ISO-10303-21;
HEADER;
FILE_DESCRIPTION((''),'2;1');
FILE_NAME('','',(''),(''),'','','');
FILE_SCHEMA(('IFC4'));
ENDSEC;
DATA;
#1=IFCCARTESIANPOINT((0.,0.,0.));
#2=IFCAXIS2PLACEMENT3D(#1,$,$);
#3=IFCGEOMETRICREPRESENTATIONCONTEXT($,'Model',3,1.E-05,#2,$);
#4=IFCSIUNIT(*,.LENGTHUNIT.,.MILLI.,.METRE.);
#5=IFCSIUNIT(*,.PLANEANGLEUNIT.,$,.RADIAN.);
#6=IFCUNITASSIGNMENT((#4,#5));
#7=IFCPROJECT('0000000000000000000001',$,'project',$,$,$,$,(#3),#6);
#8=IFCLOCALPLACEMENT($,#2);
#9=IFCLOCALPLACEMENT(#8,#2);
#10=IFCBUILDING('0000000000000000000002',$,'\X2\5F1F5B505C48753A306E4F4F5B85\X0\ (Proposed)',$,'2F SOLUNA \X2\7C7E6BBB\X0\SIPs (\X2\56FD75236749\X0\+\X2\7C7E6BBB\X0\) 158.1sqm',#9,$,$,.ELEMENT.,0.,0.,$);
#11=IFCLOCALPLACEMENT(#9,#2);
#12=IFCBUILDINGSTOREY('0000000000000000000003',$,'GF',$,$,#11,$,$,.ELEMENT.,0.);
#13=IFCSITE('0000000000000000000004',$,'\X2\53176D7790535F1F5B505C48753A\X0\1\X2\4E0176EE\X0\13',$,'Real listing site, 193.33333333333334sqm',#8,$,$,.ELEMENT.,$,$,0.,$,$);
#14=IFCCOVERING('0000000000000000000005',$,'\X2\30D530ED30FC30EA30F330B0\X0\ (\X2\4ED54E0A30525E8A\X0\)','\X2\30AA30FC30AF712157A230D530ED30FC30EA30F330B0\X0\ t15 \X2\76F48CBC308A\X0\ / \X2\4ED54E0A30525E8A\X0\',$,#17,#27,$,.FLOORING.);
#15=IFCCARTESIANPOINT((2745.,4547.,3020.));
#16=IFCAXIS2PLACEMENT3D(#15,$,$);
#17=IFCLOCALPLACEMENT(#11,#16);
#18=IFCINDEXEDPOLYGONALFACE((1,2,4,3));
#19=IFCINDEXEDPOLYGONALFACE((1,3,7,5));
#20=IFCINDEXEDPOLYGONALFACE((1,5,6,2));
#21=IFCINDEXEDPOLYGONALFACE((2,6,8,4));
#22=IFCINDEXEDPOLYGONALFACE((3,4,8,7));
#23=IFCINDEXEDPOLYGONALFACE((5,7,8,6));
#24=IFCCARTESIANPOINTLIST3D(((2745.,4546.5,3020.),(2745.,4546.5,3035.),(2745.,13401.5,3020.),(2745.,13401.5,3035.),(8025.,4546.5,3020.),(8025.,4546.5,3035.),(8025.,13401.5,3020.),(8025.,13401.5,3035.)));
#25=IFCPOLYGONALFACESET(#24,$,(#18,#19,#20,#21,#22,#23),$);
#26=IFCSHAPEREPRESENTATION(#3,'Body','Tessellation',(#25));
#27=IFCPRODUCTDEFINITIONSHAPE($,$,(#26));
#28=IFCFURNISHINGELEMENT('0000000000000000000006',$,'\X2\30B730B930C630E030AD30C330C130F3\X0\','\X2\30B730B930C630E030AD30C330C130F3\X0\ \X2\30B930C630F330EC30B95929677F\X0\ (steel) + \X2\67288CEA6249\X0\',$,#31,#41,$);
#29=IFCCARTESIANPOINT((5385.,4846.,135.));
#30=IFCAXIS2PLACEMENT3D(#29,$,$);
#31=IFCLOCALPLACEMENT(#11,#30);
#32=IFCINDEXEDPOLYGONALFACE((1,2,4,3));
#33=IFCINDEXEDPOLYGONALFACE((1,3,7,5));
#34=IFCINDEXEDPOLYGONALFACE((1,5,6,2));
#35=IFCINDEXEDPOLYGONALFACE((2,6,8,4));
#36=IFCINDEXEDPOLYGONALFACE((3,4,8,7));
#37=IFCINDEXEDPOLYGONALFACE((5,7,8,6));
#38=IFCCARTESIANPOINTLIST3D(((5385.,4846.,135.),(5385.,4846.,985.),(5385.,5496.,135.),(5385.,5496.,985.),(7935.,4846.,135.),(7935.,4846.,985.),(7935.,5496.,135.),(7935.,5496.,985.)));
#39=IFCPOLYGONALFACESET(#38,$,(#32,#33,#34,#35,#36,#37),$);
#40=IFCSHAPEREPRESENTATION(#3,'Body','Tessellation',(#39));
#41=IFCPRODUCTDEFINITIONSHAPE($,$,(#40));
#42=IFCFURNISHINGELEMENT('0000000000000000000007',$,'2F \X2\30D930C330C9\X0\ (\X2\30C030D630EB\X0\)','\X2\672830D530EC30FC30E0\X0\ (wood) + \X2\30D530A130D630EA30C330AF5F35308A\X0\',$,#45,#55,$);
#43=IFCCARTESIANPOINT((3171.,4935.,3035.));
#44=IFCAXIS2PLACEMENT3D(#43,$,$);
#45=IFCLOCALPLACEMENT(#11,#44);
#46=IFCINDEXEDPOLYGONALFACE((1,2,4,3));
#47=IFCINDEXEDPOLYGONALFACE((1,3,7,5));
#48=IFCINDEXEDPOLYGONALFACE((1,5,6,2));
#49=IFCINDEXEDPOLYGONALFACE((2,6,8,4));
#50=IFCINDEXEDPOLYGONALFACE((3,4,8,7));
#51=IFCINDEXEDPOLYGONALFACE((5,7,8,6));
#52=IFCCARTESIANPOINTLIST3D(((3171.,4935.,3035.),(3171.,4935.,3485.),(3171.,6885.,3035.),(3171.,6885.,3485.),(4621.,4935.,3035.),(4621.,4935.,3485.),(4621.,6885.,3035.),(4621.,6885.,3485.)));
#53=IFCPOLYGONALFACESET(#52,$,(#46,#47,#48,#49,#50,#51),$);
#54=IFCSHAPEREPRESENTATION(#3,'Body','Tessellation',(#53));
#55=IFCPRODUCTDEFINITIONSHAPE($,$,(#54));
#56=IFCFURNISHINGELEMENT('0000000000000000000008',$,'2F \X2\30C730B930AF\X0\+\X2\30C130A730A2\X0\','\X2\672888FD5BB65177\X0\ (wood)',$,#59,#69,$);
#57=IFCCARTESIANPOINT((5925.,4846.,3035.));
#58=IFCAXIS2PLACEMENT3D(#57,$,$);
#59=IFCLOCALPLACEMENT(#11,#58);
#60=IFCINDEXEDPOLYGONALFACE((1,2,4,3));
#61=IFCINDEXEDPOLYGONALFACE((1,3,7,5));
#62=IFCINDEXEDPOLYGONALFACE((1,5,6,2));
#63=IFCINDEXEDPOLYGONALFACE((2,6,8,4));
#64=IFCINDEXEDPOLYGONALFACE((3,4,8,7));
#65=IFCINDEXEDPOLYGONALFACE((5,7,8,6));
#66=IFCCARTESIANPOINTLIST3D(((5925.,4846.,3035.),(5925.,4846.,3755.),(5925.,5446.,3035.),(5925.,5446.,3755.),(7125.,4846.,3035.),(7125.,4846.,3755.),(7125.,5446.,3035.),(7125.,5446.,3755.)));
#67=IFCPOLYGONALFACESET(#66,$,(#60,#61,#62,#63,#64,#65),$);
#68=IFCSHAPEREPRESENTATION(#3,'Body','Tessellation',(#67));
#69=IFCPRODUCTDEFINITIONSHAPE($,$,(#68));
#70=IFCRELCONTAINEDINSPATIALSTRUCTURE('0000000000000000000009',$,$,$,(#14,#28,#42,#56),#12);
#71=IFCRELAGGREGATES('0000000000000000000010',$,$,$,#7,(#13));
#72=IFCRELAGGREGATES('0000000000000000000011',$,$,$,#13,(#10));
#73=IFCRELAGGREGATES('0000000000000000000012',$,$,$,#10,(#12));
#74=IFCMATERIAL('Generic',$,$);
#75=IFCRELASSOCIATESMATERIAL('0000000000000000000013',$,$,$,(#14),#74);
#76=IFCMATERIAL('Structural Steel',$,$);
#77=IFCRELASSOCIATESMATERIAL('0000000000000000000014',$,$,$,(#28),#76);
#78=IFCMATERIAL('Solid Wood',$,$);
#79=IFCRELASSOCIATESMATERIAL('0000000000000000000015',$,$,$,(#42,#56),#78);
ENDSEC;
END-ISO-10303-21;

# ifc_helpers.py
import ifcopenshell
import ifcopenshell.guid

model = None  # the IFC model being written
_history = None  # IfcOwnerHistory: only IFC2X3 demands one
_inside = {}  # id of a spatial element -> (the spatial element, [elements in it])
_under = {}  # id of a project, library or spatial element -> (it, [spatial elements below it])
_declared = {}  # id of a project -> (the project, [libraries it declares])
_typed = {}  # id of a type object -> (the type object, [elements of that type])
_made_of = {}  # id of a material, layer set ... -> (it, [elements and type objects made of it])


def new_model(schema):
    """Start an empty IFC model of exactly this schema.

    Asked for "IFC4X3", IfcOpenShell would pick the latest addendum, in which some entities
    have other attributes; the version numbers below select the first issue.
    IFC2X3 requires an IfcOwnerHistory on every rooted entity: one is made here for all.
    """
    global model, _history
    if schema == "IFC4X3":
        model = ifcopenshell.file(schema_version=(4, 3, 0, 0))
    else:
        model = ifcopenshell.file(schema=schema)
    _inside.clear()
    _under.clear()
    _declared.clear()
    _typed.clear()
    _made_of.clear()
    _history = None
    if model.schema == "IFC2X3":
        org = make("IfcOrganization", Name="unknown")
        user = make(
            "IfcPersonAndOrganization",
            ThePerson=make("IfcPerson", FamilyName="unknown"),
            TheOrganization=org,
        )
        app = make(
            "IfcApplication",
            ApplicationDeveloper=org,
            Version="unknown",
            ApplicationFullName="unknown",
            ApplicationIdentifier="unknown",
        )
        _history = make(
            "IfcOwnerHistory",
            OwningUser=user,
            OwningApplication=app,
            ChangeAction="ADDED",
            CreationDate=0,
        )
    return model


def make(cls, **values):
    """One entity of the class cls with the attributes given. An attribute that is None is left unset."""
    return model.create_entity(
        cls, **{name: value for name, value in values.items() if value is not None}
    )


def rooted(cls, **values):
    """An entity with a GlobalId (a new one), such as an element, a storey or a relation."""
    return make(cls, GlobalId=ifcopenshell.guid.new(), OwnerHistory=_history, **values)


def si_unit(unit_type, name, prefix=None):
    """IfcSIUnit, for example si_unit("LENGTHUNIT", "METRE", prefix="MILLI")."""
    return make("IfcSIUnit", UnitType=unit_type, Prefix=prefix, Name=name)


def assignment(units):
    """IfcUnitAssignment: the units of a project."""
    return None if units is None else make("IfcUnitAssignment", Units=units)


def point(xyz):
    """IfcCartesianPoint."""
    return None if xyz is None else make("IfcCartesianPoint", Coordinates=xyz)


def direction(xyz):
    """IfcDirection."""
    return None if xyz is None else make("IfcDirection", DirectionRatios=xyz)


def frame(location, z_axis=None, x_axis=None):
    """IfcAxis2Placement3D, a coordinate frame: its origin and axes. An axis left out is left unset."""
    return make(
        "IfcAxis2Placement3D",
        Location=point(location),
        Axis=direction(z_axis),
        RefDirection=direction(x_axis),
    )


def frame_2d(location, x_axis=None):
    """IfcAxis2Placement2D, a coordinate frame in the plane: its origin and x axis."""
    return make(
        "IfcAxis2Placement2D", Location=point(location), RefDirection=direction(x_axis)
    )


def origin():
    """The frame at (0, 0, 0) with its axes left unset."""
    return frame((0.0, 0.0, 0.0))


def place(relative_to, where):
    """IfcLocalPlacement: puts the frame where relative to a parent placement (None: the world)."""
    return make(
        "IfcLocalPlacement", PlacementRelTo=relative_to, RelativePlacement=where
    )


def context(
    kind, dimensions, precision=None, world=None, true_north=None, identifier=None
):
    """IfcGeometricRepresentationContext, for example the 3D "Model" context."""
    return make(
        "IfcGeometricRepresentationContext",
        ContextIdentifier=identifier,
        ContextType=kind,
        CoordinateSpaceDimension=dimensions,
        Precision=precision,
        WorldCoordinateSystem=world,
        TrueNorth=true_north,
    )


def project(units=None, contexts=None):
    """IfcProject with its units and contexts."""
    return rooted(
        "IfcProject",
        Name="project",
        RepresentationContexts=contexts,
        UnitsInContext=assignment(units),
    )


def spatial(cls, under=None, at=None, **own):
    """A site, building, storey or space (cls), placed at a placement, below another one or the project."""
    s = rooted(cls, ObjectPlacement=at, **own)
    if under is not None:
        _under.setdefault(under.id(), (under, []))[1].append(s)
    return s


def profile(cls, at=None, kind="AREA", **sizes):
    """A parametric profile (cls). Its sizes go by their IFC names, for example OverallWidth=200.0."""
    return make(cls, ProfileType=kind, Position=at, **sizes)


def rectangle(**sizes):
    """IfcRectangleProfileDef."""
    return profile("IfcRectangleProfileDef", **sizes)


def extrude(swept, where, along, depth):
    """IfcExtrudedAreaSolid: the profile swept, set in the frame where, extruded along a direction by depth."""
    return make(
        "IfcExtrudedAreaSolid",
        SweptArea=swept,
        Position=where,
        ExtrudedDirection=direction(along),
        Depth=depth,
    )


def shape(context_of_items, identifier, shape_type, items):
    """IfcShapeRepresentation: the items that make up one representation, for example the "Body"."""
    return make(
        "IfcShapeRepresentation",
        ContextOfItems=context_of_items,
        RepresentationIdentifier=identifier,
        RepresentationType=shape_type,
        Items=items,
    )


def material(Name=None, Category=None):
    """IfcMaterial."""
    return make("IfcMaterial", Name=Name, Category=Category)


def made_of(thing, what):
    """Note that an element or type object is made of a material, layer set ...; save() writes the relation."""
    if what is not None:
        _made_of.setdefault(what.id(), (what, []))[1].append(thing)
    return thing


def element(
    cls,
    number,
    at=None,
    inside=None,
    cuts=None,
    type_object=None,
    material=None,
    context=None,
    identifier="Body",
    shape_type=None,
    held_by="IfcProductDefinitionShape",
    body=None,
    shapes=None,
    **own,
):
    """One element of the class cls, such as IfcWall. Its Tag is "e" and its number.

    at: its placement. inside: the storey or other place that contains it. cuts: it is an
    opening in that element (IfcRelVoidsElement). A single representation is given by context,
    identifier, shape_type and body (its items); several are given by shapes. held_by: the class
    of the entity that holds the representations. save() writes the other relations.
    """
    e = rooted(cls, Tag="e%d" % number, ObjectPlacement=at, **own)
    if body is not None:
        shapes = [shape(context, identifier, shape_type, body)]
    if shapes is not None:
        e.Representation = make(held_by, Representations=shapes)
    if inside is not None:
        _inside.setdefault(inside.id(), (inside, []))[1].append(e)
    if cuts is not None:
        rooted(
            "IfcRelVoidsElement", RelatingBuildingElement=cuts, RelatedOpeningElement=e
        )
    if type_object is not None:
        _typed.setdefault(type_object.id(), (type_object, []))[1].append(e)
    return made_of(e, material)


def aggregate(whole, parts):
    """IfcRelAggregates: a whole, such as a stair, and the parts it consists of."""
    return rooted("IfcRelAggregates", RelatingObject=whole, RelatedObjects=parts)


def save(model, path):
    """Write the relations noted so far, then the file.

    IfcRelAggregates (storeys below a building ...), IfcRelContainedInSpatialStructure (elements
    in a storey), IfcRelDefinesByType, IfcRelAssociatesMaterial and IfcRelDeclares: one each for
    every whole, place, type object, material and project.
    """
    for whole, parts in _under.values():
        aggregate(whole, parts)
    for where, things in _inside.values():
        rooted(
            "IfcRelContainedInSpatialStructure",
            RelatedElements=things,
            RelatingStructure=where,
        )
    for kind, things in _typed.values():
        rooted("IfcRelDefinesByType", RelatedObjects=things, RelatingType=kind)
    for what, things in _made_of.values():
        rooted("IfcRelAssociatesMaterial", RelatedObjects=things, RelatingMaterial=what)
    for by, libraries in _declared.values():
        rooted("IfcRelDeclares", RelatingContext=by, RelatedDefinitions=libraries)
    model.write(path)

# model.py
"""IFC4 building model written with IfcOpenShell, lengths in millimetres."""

from ifc_helpers import new_model, si_unit, frame, frame_2d, origin, place, context, project, spatial, rectangle, extrude, material, element, save


model = new_model("IFC4")

# Units and contexts
model_context = context("Model", 3, precision=1e-05, world=origin())
ifc_project = project(units=[si_unit("LENGTHUNIT", "METRE", prefix="MILLI"), si_unit("PLANEANGLEUNIT", "RADIAN")], contexts=[model_context])

# Site, building, storey
site_placement = place(None, origin())
site = spatial("IfcSite", under=ifc_project, at=site_placement, Name="北海道弟子屈町1丁目13", ObjectType="Real listing site, 193.33333333333334sqm", CompositionType="ELEMENT", RefElevation=0.0)
building_placement = place(site_placement, origin())
building = spatial("IfcBuilding", under=site, at=building_placement, Name="弟子屈町の住宅 (Proposed)", ObjectType="2F SOLUNA 籾殻SIPs (国産杉+籾殻) 158.1sqm", CompositionType="ELEMENT", ElevationOfRefHeight=0.0, ElevationOfTerrain=0.0)
storey_placement = place(building_placement, origin())
storey = spatial("IfcBuildingStorey", under=building, at=storey_placement, Name="GF", CompositionType="ELEMENT", Elevation=0.0)

# Shared definitions
ifc_material_1 = material(Name="Solid Wood")

# Shared definitions
ifc_material_2 = material(Name="Generic")

# Shared definitions
ifc_material_3 = material(Name="Structural Steel")

# Covering
covering_placement = place(storey_placement, frame((2745.0, 4547.0, 3020.0)))
element("IfcCovering", 1, at=covering_placement, inside=storey, material=ifc_material_2, Name="フローリング (仕上げ床)", Description="オーク無垢フローリング t15 直貼り / 仕上げ床", PredefinedType="FLOORING", context=model_context, shape_type="SweptSolid", body=[
    extrude(rectangle(XDim=5280.0, YDim=8855.0, at=frame_2d((2640.0, 4427.0))), frame((2745.0, 4547.0, 3020.0)), (0.0, 0.0, 1.0), 15.0),
])

# Furnishing elements
furnishing_1_placement = place(storey_placement, frame((5385.0, 4846.0, 135.0)))
element("IfcFurnishingElement", 2, at=furnishing_1_placement, inside=storey, material=ifc_material_3, Name="システムキッチン", Description="システムキッチン ステンレス天板 (steel) + 木質扉", context=model_context, shape_type="SweptSolid", body=[
    extrude(rectangle(XDim=2550.0, YDim=650.0, at=frame_2d((1275.0, 325.0))), frame((5385.0, 4846.0, 135.0)), (0.0, 0.0, 1.0), 850.0),
])
furnishing_2_placement = place(storey_placement, frame((3171.0, 4935.0, 3035.0)))
element("IfcFurnishingElement", 3, at=furnishing_2_placement, inside=storey, material=ifc_material_1, Name="2F ベッド (ダブル)", Description="木フレーム (wood) + ファブリック張り", context=model_context, shape_type="SweptSolid", body=[
    extrude(rectangle(XDim=1450.0, YDim=1950.0, at=frame_2d((725.0, 975.0))), frame((3171.0, 4935.0, 3035.0)), (0.0, 0.0, 1.0), 450.0),
])
furnishing_3_placement = place(storey_placement, frame((5925.0, 4846.0, 3035.0)))
element("IfcFurnishingElement", 4, at=furnishing_3_placement, inside=storey, material=ifc_material_1, Name="2F デスク+チェア", Description="木製家具 (wood)", context=model_context, shape_type="SweptSolid", body=[
    extrude(rectangle(XDim=1200.0, YDim=600.0, at=frame_2d((600.0, 300.0))), frame((5925.0, 4846.0, 3035.0)), (0.0, 0.0, 1.0), 720.0),
])

save(model, "model.ifc")
